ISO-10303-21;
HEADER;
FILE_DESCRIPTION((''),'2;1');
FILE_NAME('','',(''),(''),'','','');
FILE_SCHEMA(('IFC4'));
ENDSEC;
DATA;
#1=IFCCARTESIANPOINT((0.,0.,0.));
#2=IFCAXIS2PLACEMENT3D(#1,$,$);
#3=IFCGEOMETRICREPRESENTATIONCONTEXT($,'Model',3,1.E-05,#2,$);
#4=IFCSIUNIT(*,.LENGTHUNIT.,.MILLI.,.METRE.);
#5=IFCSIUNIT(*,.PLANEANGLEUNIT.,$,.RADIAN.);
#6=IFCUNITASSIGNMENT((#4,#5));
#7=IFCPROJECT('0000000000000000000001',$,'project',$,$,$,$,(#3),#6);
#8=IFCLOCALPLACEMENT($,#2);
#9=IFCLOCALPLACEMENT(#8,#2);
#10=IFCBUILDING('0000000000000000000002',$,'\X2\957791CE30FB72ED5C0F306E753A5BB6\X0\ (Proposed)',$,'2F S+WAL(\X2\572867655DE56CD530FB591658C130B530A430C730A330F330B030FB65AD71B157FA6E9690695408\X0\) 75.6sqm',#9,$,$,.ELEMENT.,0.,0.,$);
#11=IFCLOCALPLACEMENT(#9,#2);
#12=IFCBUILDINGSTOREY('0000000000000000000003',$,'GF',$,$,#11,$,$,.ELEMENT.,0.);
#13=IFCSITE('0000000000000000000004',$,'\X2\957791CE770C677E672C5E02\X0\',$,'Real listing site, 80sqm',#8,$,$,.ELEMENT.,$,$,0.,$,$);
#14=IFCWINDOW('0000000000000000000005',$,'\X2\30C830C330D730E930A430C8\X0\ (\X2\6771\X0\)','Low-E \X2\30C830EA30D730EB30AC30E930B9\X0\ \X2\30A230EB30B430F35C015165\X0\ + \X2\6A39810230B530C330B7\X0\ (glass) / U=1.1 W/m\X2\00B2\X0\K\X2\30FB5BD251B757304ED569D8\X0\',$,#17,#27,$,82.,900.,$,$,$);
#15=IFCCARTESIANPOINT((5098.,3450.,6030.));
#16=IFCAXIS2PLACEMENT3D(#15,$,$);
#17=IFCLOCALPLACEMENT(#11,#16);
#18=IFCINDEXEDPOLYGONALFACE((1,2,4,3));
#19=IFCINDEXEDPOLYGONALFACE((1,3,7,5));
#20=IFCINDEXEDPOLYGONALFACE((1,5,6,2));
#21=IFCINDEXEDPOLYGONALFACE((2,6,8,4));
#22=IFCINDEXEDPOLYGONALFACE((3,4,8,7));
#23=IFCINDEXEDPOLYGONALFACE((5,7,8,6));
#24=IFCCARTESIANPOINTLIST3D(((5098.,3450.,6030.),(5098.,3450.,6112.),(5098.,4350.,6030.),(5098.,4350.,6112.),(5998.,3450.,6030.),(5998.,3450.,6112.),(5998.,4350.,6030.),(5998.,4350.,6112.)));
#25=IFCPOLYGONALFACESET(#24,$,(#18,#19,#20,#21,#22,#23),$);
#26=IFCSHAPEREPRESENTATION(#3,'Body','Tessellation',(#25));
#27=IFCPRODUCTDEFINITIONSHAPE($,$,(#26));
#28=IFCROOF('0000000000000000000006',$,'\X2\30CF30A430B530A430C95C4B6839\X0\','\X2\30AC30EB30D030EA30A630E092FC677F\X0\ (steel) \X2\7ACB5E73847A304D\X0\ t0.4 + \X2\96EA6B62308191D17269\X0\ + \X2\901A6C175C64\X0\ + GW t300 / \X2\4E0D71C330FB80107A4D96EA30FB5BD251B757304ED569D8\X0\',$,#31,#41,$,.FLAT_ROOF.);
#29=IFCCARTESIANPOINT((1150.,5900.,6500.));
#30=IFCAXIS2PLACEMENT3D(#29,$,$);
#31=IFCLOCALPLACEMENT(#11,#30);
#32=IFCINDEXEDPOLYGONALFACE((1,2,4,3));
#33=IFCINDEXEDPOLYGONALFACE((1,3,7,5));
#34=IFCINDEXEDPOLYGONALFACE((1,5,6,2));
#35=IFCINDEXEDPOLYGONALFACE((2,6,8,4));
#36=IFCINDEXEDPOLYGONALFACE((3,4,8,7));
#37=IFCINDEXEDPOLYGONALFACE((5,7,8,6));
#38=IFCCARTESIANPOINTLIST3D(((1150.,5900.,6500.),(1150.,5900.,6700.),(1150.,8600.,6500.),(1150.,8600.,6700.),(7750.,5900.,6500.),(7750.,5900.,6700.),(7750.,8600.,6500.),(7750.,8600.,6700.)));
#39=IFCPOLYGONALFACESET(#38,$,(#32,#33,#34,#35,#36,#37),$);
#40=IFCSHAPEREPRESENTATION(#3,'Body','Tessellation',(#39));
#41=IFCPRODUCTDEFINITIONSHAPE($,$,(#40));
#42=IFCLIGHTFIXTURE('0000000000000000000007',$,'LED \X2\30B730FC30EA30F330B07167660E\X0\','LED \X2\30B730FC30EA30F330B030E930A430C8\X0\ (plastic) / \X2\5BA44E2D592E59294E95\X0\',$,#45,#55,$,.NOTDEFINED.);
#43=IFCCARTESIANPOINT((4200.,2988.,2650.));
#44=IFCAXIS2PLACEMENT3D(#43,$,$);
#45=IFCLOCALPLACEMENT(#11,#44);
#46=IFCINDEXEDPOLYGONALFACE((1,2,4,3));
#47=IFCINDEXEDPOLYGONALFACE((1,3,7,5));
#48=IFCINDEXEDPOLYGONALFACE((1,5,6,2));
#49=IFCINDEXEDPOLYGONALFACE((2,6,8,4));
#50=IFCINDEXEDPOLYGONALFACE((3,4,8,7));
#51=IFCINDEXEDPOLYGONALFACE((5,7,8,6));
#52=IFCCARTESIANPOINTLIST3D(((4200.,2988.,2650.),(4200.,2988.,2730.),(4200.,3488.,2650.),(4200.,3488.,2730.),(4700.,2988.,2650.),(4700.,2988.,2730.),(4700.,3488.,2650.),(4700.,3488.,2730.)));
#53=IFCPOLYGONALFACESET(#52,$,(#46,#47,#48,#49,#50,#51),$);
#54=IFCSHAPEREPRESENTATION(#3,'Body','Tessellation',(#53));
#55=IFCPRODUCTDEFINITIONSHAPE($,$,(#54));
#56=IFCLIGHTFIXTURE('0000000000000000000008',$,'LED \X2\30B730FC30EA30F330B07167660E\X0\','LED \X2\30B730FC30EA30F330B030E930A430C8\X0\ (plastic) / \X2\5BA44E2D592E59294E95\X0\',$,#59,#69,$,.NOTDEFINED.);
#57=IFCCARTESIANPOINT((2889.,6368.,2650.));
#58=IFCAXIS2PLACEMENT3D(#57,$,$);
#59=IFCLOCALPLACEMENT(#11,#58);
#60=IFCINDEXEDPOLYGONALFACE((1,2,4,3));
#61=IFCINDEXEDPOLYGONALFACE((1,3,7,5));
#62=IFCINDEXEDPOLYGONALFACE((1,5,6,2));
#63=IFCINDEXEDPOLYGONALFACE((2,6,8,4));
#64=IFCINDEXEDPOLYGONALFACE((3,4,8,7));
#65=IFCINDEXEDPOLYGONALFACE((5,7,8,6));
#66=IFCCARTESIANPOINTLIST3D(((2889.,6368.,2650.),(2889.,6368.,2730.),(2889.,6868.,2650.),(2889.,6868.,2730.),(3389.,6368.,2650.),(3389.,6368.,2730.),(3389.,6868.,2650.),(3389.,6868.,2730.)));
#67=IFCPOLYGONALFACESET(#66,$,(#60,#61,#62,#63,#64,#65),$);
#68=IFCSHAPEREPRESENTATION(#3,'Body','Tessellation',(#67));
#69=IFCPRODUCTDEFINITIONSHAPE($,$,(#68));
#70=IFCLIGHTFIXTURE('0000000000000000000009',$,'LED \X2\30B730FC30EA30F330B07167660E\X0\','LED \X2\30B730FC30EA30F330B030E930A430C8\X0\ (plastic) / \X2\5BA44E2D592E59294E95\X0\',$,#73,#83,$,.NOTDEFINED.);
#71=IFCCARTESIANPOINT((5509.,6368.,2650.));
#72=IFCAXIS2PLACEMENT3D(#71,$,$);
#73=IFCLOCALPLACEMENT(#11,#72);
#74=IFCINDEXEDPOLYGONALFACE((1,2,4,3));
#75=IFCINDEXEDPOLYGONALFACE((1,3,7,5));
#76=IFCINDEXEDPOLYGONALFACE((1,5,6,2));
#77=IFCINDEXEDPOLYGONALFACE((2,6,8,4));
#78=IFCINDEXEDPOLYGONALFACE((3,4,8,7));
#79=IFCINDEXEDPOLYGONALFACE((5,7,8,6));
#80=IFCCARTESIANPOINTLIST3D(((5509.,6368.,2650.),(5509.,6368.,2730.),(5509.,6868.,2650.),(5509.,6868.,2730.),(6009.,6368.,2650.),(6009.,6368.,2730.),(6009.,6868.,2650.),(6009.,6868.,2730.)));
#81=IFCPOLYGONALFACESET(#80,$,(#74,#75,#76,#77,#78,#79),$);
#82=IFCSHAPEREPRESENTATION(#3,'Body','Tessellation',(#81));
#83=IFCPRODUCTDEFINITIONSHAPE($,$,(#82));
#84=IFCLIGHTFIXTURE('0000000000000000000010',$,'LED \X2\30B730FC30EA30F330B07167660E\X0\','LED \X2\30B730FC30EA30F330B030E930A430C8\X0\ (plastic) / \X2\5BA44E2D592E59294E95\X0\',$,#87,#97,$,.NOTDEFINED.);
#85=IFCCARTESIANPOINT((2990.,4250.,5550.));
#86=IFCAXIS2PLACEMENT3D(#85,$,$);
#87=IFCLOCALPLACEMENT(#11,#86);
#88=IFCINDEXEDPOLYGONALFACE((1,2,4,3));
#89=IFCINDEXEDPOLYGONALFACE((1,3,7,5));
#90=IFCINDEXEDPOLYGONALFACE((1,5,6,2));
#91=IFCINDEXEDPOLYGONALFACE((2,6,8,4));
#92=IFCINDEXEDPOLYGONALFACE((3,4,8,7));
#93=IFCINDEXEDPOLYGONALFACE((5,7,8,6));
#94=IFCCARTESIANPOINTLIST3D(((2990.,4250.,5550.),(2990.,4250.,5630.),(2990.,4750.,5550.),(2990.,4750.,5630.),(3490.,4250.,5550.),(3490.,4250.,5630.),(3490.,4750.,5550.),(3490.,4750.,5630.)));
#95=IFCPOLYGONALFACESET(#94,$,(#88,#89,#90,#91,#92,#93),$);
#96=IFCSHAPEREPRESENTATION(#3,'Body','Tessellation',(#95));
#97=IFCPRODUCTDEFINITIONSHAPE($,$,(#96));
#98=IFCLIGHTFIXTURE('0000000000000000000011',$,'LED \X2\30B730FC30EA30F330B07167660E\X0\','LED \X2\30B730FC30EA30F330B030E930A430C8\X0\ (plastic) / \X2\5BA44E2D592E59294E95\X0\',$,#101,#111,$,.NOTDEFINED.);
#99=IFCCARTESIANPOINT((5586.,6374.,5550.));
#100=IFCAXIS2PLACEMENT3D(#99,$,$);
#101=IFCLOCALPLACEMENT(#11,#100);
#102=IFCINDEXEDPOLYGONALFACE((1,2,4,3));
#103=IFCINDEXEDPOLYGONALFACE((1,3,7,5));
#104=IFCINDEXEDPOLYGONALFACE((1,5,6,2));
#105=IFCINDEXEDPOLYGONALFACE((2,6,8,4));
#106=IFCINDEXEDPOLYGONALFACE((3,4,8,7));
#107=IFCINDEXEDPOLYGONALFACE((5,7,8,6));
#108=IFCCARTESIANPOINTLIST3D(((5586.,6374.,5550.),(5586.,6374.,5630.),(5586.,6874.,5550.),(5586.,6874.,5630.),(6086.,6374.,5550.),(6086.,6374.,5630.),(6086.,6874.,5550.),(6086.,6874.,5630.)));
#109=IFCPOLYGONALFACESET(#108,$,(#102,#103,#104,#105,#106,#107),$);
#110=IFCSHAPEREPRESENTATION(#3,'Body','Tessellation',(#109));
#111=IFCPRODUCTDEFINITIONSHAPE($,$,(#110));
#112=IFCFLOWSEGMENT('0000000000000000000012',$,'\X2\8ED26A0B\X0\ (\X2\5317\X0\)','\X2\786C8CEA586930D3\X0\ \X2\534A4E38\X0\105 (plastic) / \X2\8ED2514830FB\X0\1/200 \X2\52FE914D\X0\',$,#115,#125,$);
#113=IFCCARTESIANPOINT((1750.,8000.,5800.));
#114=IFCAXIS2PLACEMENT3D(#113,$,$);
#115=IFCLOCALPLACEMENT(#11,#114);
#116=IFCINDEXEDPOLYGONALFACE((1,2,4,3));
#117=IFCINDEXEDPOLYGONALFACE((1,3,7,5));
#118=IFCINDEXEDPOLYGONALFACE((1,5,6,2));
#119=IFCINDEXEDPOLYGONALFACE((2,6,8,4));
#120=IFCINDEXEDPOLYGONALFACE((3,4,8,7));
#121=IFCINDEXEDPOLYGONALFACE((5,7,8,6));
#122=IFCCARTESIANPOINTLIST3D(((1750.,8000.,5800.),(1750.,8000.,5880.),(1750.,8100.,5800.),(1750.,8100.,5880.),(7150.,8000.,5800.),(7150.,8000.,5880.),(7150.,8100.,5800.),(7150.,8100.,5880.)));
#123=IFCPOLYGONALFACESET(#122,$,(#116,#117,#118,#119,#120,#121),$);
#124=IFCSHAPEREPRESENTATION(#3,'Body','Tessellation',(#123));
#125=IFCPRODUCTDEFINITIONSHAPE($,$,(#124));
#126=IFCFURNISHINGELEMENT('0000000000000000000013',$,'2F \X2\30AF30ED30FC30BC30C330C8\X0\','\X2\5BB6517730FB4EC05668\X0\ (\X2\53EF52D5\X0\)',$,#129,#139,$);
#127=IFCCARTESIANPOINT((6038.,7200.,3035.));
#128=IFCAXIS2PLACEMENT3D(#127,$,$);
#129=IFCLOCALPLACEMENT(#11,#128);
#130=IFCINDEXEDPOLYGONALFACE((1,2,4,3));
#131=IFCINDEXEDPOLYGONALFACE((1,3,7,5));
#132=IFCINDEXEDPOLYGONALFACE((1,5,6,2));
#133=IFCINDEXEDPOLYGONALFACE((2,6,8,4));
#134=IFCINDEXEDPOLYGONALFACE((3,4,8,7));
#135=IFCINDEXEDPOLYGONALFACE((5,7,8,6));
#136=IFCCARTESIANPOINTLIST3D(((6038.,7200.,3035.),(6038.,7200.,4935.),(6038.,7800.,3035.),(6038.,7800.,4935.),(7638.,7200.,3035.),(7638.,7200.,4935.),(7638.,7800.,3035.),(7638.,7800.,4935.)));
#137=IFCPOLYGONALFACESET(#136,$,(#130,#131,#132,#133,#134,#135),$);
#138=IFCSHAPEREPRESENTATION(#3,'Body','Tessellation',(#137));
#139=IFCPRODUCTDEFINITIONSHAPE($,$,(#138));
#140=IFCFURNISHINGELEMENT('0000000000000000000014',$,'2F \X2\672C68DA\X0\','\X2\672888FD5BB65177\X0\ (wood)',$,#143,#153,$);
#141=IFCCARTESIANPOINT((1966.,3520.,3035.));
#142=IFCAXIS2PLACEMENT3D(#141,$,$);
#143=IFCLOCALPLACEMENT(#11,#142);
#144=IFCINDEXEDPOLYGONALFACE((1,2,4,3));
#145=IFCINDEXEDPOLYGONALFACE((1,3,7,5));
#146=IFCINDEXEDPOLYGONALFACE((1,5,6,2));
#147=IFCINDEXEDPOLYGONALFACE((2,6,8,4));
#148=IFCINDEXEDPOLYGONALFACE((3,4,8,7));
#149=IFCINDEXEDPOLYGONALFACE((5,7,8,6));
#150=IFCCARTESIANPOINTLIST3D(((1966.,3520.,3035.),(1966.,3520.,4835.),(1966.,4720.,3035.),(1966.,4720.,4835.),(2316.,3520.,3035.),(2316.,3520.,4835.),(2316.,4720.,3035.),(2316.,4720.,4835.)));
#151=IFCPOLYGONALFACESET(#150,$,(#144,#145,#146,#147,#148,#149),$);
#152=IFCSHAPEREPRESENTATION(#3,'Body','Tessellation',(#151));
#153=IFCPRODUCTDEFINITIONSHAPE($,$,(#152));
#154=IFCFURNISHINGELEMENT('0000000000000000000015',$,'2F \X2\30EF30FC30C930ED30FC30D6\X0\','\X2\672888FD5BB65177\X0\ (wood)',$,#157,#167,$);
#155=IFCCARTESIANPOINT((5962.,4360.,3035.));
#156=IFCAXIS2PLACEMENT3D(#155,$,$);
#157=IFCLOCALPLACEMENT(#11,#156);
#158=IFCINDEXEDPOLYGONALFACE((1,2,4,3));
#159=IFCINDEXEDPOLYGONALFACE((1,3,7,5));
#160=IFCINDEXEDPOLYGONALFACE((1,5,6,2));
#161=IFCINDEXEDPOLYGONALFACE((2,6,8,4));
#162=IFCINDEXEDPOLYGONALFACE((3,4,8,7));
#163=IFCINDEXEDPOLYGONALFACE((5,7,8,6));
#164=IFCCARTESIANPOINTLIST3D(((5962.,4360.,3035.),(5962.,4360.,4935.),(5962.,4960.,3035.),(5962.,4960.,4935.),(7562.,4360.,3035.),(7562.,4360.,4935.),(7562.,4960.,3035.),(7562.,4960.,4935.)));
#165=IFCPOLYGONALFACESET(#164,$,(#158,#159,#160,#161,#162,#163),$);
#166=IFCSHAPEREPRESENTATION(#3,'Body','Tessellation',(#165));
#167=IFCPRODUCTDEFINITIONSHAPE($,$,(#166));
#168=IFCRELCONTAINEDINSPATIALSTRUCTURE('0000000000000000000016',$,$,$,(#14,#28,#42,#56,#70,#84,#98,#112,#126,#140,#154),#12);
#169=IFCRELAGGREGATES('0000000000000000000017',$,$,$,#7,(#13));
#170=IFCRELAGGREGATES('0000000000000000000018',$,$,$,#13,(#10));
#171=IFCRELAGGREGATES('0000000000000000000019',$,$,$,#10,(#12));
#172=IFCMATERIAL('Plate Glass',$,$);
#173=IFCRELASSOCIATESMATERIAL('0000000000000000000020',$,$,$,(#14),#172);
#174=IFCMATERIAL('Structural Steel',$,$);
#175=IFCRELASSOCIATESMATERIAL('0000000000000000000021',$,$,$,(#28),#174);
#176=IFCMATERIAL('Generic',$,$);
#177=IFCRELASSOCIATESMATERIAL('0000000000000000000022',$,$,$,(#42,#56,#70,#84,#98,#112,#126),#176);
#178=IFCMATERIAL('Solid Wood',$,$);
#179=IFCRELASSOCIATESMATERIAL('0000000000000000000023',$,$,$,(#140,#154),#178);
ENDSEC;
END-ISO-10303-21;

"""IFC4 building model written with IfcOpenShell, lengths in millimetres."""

from ifc_helpers import new_model, si_unit, frame, frame_2d, origin, place, context, project, spatial, rectangle, extrude, material, element, save


model = new_model("IFC4")

# Units and contexts
model_context = context("Model", 3, precision=1e-05, world=origin())
ifc_project = project(units=[si_unit("LENGTHUNIT", "METRE", prefix="MILLI"), si_unit("PLANEANGLEUNIT", "RADIAN")], contexts=[model_context])

# Site, building, storey
site_placement = place(None, origin())
site = spatial("IfcSite", under=ifc_project, at=site_placement, Name="長野県松本市", ObjectType="Real listing site, 80sqm", CompositionType="ELEMENT", RefElevation=0.0)
building_placement = place(site_placement, origin())
building = spatial("IfcBuilding", under=site, at=building_placement, Name="長野・狭小の町家 (Proposed)", ObjectType="2F S+WAL(在来工法・外壁サイディング・断熱基準適合) 75.6sqm", CompositionType="ELEMENT", ElevationOfRefHeight=0.0, ElevationOfTerrain=0.0)
storey_placement = place(building_placement, origin())
storey = spatial("IfcBuildingStorey", under=building, at=storey_placement, Name="GF", CompositionType="ELEMENT", Elevation=0.0)

# Shared definitions
ifc_material_1 = material(Name="Solid Wood")

# Shared definitions
ifc_material_2 = material(Name="Plate Glass")

# Window
window_1_placement = place(storey_placement, frame((5098.0, 3450.0, 6030.0)))
element("IfcWindow", 1, at=window_1_placement, inside=storey, material=ifc_material_2, Name="トップライト (東)", Description="Low-E トリプルガラス アルゴン封入 + 樹脂サッシ (glass) / U=1.1 W/m²K・寒冷地仕様", OverallHeight=82.0, OverallWidth=900.0, context=model_context, shape_type="SweptSolid", body=[
    extrude(rectangle(XDim=900.0, YDim=900.0, at=frame_2d((450.0, 450.0))), frame((5098.0, 3450.0, 6030.0)), (0.0, 0.0, 1.0), 82.0),
])

# Roof
ifc_material_3 = material(Name="Structural Steel")
roof_placement = place(storey_placement, frame((1150.0, 5900.0, 6500.0)))
element("IfcRoof", 2, at=roof_placement, inside=storey, material=ifc_material_3, Name="ハイサイド屋根", Description="ガルバリウム鋼板 (steel) 立平葺き t0.4 + 雪止め金物 + 通気層 + GW t300 / 不燃・耐積雪・寒冷地仕様", PredefinedType="FLAT_ROOF", context=model_context, shape_type="SweptSolid", body=[
    extrude(rectangle(XDim=6600.0, YDim=2700.0, at=frame_2d((3300.0, 1350.0))), frame((1150.0, 5900.0, 6500.0)), (0.0, 0.0, 1.0), 200.0),
])

# Light fixtures
ifc_material_4 = material(Name="Generic")
light_fixture_1_placement = place(storey_placement, frame((4200.0, 2988.0, 2650.0)))
element("IfcLightFixture", 3, at=light_fixture_1_placement, inside=storey, material=ifc_material_4, Name="LED シーリング照明", Description="LED シーリングライト (plastic) / 室中央天井", PredefinedType="NOTDEFINED", context=model_context, shape_type="SweptSolid", body=[
    extrude(rectangle(XDim=500.0, YDim=500.0, at=frame_2d((250.0, 250.0))), frame((4200.0, 2988.0, 2650.0)), (0.0, 0.0, 1.0), 80.0),
])
light_fixture_2_placement = place(storey_placement, frame((2889.0, 6368.0, 2650.0)))
element("IfcLightFixture", 4, at=light_fixture_2_placement, inside=storey, material=ifc_material_4, Name="LED シーリング照明", Description="LED シーリングライト (plastic) / 室中央天井", PredefinedType="NOTDEFINED", context=model_context, shape_type="SweptSolid", body=[
    extrude(rectangle(XDim=500.0, YDim=500.0, at=frame_2d((250.0, 250.0))), frame((2889.0, 6368.0, 2650.0)), (0.0, 0.0, 1.0), 80.0),
])
light_fixture_3_placement = place(storey_placement, frame((5509.0, 6368.0, 2650.0)))
element("IfcLightFixture", 5, at=light_fixture_3_placement, inside=storey, material=ifc_material_4, Name="LED シーリング照明", Description="LED シーリングライト (plastic) / 室中央天井", PredefinedType="NOTDEFINED", context=model_context, shape_type="SweptSolid", body=[
    extrude(rectangle(XDim=500.0, YDim=500.0, at=frame_2d((250.0, 250.0))), frame((5509.0, 6368.0, 2650.0)), (0.0, 0.0, 1.0), 80.0),
])
light_fixture_4_placement = place(storey_placement, frame((2990.0, 4250.0, 5550.0)))
element("IfcLightFixture", 6, at=light_fixture_4_placement, inside=storey, material=ifc_material_4, Name="LED シーリング照明", Description="LED シーリングライト (plastic) / 室中央天井", PredefinedType="NOTDEFINED", context=model_context, shape_type="SweptSolid", body=[
    extrude(rectangle(XDim=500.0, YDim=500.0, at=frame_2d((250.0, 250.0))), frame((2990.0, 4250.0, 5550.0)), (0.0, 0.0, 1.0), 80.0),
])
light_fixture_5_placement = place(storey_placement, frame((5586.0, 6374.0, 5550.0)))
element("IfcLightFixture", 7, at=light_fixture_5_placement, inside=storey, material=ifc_material_4, Name="LED シーリング照明", Description="LED シーリングライト (plastic) / 室中央天井", PredefinedType="NOTDEFINED", context=model_context, shape_type="SweptSolid", body=[
    extrude(rectangle(XDim=500.0, YDim=500.0, at=frame_2d((250.0, 250.0))), frame((5586.0, 6374.0, 5550.0)), (0.0, 0.0, 1.0), 80.0),
])

# Flow segment
flow_segment_placement = place(storey_placement, frame((1750.0, 8000.0, 5800.0)))
element("IfcFlowSegment", 8, at=flow_segment_placement, inside=storey, material=ifc_material_4, Name="軒樋 (北)", Description="硬質塩ビ 半丸105 (plastic) / 軒先・1/200 勾配", context=model_context, shape_type="SweptSolid", body=[
    extrude(rectangle(XDim=5400.0, YDim=100.0, at=frame_2d((2700.0, 50.0))), frame((1750.0, 8000.0, 5800.0)), (0.0, 0.0, 1.0), 80.0),
])

# Furnishing elements
furnishing_1_placement = place(storey_placement, frame((6038.0, 7200.0, 3035.0)))
element("IfcFurnishingElement", 9, at=furnishing_1_placement, inside=storey, material=ifc_material_4, Name="2F クローゼット", Description="家具・什器 (可動)", context=model_context, shape_type="SweptSolid", body=[
    extrude(rectangle(XDim=1600.0, YDim=600.0, at=frame_2d((800.0, 300.0))), frame((6038.0, 7200.0, 3035.0)), (0.0, 0.0, 1.0), 1900.0),
])
furnishing_2_placement = place(storey_placement, frame((1966.0, 3520.0, 3035.0)))
element("IfcFurnishingElement", 10, at=furnishing_2_placement, inside=storey, material=ifc_material_1, Name="2F 本棚", Description="木製家具 (wood)", context=model_context, shape_type="SweptSolid", body=[
    extrude(rectangle(XDim=350.0, YDim=1200.0, at=frame_2d((175.0, 600.0))), frame((1966.0, 3520.0, 3035.0)), (0.0, 0.0, 1.0), 1800.0),
])
furnishing_3_placement = place(storey_placement, frame((5962.0, 4360.0, 3035.0)))
element("IfcFurnishingElement", 11, at=furnishing_3_placement, inside=storey, material=ifc_material_1, Name="2F ワードローブ", Description="木製家具 (wood)", context=model_context, shape_type="SweptSolid", body=[
    extrude(rectangle(XDim=1600.0, YDim=600.0, at=frame_2d((800.0, 300.0))), frame((5962.0, 4360.0, 3035.0)), (0.0, 0.0, 1.0), 1900.0),
])

save(model, "model.ifc")
